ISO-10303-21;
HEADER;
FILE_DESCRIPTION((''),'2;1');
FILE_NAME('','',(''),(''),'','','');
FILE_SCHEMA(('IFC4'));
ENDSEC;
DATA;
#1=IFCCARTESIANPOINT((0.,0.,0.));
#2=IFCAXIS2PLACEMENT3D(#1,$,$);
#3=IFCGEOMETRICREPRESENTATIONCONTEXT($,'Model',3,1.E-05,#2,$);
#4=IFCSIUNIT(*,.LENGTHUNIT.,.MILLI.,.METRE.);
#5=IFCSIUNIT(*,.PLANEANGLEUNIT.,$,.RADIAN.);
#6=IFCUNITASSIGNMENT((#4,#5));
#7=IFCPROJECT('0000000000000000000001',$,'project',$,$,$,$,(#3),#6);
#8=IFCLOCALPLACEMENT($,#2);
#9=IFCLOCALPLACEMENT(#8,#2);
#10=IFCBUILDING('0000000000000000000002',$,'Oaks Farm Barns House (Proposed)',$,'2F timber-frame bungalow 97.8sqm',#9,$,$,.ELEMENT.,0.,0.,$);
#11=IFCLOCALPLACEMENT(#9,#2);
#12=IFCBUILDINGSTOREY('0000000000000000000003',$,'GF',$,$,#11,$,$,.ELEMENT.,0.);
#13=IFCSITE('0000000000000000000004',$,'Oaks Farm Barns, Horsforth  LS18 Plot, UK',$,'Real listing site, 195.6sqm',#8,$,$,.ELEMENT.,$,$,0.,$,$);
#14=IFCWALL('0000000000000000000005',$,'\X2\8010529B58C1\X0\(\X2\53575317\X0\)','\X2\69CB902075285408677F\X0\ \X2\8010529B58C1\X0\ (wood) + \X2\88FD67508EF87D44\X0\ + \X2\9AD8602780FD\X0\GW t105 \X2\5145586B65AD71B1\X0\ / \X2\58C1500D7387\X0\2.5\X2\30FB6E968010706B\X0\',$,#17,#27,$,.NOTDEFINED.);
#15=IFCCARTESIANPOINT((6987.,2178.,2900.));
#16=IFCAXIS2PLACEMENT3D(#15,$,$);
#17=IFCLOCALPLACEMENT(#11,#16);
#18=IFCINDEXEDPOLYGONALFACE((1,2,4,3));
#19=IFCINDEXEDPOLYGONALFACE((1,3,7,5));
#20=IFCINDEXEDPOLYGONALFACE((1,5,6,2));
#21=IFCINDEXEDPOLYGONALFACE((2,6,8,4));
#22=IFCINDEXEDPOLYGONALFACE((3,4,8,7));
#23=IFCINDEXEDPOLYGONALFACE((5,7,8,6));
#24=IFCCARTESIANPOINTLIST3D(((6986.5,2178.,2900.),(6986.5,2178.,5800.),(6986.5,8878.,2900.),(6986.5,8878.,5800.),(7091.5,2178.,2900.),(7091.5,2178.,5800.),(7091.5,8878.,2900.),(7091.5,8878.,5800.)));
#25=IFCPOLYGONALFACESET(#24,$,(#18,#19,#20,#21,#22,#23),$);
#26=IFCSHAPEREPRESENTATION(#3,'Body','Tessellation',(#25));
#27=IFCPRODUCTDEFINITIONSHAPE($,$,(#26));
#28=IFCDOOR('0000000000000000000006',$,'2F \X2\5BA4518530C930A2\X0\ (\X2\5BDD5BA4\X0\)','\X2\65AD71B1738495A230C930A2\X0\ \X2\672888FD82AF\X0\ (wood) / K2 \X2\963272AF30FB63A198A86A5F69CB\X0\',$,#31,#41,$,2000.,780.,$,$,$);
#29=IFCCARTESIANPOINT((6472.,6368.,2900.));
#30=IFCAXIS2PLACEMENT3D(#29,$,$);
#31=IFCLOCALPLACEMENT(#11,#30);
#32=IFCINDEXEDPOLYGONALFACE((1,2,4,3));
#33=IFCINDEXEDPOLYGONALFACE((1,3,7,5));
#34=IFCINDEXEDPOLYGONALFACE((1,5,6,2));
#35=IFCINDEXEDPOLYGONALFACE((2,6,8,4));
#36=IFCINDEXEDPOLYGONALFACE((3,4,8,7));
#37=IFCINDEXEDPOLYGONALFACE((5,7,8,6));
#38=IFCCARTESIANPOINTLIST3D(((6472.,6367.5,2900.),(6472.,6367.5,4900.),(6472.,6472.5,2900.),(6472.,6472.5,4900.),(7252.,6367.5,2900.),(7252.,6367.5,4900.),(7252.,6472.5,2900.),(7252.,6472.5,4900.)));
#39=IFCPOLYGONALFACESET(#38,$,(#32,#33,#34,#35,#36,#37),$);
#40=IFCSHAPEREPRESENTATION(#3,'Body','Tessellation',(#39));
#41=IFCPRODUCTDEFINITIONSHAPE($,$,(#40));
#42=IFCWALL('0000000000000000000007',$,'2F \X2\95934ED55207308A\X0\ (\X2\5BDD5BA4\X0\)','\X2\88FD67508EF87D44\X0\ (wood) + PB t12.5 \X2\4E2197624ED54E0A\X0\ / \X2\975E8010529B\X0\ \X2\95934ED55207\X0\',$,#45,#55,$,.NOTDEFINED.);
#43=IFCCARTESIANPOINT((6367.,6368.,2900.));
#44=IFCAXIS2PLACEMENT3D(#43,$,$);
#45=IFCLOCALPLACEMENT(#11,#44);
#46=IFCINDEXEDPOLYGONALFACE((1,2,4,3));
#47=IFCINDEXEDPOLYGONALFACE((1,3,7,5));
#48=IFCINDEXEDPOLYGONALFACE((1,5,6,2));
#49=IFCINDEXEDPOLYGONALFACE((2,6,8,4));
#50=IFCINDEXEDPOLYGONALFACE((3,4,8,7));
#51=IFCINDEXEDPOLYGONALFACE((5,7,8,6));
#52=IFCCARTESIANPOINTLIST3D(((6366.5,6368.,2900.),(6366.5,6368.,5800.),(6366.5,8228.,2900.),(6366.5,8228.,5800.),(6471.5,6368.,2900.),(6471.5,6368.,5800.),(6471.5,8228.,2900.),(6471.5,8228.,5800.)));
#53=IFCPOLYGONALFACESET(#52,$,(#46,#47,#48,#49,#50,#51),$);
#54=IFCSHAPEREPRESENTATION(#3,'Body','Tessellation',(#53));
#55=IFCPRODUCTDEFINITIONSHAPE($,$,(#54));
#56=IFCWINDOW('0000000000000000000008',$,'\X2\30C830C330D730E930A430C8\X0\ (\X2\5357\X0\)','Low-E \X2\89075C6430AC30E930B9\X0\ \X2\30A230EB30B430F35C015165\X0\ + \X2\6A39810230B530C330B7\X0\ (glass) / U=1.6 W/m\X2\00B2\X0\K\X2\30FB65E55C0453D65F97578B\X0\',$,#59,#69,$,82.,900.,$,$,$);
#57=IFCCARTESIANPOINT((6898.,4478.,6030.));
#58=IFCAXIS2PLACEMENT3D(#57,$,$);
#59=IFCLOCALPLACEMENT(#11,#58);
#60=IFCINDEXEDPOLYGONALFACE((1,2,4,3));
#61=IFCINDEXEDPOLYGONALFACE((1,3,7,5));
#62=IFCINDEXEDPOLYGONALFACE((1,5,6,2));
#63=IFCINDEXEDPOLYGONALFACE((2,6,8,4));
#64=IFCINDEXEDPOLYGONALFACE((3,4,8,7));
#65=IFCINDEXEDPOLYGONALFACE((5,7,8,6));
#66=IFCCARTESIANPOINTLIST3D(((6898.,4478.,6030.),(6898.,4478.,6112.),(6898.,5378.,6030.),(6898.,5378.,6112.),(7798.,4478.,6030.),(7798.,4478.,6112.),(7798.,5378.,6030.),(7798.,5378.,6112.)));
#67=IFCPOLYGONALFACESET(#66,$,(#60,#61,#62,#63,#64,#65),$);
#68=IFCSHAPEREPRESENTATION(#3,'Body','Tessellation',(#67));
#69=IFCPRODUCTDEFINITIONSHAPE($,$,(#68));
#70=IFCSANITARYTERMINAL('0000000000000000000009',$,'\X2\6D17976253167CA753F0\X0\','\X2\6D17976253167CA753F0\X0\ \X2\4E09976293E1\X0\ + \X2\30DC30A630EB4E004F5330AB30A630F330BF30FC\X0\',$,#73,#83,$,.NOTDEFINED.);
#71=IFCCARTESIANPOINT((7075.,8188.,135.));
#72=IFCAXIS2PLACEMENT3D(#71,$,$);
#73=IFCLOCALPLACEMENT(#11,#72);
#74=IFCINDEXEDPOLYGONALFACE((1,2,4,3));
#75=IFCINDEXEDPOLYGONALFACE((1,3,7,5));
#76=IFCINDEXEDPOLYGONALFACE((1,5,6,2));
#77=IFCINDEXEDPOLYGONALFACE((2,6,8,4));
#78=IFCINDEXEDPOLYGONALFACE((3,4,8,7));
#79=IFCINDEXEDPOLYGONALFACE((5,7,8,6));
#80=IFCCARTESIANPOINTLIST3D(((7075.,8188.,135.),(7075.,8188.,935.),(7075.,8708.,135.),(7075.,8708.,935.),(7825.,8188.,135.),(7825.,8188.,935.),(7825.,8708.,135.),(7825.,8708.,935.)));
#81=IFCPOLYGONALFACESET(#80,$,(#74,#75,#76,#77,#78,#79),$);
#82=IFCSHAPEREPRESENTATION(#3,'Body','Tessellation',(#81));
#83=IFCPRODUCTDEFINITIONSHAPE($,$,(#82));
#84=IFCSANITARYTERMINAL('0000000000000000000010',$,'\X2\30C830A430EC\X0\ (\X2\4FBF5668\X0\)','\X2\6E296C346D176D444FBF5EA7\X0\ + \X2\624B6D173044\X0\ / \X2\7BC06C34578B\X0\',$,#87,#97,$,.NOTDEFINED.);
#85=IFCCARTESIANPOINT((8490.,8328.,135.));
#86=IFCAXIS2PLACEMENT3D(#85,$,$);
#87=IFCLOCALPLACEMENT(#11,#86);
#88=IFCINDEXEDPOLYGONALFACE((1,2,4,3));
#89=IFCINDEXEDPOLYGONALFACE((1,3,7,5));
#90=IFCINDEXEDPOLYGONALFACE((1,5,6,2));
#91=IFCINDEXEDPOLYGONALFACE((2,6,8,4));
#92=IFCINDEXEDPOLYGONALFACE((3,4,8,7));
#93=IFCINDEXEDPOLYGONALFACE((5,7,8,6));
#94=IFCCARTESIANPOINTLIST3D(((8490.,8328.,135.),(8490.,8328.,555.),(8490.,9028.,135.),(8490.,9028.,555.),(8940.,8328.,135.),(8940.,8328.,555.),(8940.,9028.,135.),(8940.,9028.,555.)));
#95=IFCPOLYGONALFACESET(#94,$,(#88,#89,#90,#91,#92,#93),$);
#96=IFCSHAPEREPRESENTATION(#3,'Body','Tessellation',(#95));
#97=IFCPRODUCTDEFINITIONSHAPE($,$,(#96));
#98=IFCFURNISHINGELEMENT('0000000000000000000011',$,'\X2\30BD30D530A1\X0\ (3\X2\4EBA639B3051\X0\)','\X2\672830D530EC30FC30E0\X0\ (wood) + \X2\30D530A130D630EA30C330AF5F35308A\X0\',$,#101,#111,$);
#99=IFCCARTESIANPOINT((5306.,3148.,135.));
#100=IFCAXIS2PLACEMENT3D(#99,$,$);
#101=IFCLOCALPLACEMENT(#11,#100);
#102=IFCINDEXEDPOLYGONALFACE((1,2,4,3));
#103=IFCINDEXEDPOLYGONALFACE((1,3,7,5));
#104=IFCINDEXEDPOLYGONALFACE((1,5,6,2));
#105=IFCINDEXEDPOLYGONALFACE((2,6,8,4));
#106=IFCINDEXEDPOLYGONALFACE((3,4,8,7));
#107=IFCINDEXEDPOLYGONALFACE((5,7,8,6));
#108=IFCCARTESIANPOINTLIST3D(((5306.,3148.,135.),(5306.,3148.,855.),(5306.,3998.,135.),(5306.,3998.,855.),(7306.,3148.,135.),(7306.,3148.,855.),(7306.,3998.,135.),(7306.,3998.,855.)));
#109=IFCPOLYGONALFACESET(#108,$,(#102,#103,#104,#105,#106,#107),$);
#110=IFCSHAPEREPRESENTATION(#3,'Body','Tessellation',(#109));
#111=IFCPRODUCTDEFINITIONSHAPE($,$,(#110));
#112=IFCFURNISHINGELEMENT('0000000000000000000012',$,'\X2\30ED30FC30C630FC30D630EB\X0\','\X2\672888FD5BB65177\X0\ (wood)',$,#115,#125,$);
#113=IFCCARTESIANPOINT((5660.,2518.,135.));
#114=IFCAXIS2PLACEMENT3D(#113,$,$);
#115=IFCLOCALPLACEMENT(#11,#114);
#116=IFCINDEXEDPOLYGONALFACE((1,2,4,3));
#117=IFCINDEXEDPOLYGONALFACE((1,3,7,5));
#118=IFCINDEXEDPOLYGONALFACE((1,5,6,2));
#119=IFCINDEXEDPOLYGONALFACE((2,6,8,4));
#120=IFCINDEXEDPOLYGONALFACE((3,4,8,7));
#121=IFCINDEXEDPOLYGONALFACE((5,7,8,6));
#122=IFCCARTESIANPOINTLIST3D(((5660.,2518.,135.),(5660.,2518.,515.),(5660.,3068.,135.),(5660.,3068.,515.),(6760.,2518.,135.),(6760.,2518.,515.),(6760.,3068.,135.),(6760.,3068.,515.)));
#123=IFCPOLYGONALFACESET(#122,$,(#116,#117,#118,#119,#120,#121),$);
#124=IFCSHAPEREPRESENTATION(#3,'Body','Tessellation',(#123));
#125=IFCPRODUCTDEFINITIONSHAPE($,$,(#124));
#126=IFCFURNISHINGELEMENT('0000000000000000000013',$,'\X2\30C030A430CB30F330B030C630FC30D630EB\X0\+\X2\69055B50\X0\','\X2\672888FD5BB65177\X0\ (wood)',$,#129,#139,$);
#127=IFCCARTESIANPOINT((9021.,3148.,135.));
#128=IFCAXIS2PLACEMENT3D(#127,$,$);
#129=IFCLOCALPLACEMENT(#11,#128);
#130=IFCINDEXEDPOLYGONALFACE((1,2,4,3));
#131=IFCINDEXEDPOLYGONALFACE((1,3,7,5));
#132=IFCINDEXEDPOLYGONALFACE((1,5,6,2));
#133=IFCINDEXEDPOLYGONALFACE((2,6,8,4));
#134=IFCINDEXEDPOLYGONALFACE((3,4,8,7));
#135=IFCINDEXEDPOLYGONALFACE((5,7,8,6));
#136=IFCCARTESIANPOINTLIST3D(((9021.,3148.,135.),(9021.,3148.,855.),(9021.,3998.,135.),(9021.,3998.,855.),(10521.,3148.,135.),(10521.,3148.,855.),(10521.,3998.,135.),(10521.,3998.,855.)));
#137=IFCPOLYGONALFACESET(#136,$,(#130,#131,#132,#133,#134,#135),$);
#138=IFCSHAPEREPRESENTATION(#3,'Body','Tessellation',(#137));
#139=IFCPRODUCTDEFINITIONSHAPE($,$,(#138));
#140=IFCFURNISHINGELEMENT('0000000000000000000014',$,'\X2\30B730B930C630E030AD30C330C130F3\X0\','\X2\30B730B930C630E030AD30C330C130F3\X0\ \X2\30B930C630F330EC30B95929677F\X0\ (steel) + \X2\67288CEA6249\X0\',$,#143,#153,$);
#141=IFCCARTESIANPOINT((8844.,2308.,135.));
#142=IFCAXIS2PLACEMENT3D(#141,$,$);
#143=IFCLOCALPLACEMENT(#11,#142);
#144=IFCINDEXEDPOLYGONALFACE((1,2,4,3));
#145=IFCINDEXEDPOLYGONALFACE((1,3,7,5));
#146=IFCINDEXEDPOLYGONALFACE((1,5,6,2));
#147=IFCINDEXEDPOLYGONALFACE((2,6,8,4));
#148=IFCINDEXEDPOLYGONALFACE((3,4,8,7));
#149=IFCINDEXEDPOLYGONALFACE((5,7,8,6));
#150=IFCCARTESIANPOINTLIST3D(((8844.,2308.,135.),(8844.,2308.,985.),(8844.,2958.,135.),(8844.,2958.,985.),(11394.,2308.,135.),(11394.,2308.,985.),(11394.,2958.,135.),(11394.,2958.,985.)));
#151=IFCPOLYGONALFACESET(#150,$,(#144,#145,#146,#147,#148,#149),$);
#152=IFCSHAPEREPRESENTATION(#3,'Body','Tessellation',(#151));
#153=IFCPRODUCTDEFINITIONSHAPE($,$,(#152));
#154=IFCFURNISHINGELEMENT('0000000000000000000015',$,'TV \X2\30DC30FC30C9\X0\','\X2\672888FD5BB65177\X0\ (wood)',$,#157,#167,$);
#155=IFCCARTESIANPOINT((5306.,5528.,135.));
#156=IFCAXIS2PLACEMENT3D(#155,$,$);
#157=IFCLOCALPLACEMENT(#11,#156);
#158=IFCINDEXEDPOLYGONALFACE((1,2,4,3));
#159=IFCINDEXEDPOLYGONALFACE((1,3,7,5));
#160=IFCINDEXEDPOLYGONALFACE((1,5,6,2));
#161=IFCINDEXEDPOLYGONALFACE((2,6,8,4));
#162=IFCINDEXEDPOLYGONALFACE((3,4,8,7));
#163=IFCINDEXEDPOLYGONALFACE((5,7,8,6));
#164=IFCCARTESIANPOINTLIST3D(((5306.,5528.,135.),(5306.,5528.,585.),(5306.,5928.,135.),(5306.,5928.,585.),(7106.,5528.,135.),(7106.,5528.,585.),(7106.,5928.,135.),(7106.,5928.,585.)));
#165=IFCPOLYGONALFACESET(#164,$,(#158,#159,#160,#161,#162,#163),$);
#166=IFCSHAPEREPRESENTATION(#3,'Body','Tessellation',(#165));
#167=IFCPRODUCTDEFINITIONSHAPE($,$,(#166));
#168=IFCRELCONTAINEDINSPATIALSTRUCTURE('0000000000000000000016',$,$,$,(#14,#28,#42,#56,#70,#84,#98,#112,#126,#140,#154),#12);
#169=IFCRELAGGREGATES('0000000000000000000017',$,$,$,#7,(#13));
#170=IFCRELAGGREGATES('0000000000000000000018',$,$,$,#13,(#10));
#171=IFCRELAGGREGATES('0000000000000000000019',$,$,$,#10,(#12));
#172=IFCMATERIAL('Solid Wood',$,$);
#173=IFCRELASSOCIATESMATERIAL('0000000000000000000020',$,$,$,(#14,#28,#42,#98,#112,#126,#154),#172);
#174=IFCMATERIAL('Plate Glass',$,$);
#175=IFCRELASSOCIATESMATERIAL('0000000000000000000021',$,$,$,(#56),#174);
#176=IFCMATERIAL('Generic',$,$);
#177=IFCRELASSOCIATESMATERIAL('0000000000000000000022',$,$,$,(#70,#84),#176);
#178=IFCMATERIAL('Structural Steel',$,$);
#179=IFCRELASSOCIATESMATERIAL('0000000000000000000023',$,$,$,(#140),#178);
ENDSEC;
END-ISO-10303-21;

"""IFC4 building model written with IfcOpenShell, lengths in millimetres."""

from ifc_helpers import new_model, si_unit, frame, frame_2d, origin, place, context, project, spatial, rectangle, extrude, material, element, fill, save


model = new_model("IFC4")

# Units and contexts
model_context = context("Model", 3, precision=1e-05, world=origin())
ifc_project = project(units=[si_unit("LENGTHUNIT", "METRE", prefix="MILLI"), si_unit("PLANEANGLEUNIT", "RADIAN")], contexts=[model_context])

# Site, building, storey
site_placement = place(None, origin())
site = spatial("IfcSite", under=ifc_project, at=site_placement, Name="Oaks Farm Barns, Horsforth  LS18 Plot, UK", ObjectType="Real listing site, 195.6sqm", CompositionType="ELEMENT", RefElevation=0.0)
building_placement = place(site_placement, origin())
building = spatial("IfcBuilding", under=site, at=building_placement, Name="Oaks Farm Barns House (Proposed)", ObjectType="2F timber-frame bungalow 97.8sqm", CompositionType="ELEMENT", ElevationOfRefHeight=0.0, ElevationOfTerrain=0.0)
storey_placement = place(building_placement, origin())
storey = spatial("IfcBuildingStorey", under=building, at=storey_placement, Name="GF", CompositionType="ELEMENT", Elevation=0.0)

# Shared definitions
ifc_material_1 = material(Name="Solid Wood")

# Wall, opening, door
wall_1_placement = place(storey_placement, frame((6987.0, 2178.0, 2900.0)))
wall_1 = element("IfcWall", 1, at=wall_1_placement, inside=storey, material=ifc_material_1, Name="耐力壁(南北)", Description="構造用合板 耐力壁 (wood) + 製材軸組 + 高性能GW t105 充填断熱 / 壁倍率2.5・準耐火", PredefinedType="NOTDEFINED", context=model_context, shape_type="SweptSolid", body=[
    extrude(rectangle(XDim=105.0, YDim=6700.0, at=frame_2d((52.0, 3350.0))), frame((6987.0, 2178.0, 2900.0)), (0.0, 0.0, 1.0), 2900.0),
])
opening_1_placement = place(storey_placement, frame((6472.0, 6368.0, 2900.0)))
opening_1 = element("IfcOpeningElement", 2, at=opening_1_placement, cuts=wall_1, PredefinedType="NOTDEFINED", context=model_context, shape_type="SweptSolid", body=[
    extrude(rectangle(XDim=780.0, YDim=105.0, at=frame_2d((390.0, 52.0))), frame((6472.0, 6368.0, 2900.0)), (0.0, 0.0, 1.0), 2000.0),
])
door_1_placement = place(storey_placement, frame((6472.0, 6368.0, 2900.0)))
door_1 = element("IfcDoor", 3, at=door_1_placement, inside=storey, material=ifc_material_1, Name="2F 室内ドア (寝室)", Description="断熱玄関ドア 木製芯 (wood) / K2 防犯・採風機構", OverallHeight=2000.0, OverallWidth=780.0, context=model_context, shape_type="SweptSolid", body=[
    extrude(rectangle(XDim=780.0, YDim=105.0, at=frame_2d((390.0, 52.0))), frame((6472.0, 6368.0, 2900.0)), (0.0, 0.0, 1.0), 2000.0),
])
fill(opening_1, door_1)

# Wall
wall_2_placement = place(storey_placement, frame((6367.0, 6368.0, 2900.0)))
element("IfcWall", 4, at=wall_2_placement, inside=storey, material=ifc_material_1, Name="2F 間仕切り (寝室)", Description="製材軸組 (wood) + PB t12.5 両面仕上 / 非耐力 間仕切", PredefinedType="NOTDEFINED", context=model_context, shape_type="SweptSolid", body=[
    extrude(rectangle(XDim=105.0, YDim=1860.0, at=frame_2d((52.0, 930.0))), frame((6367.0, 6368.0, 2900.0)), (0.0, 0.0, 1.0), 2900.0),
])

# Window
ifc_material_2 = material(Name="Plate Glass")
window_placement = place(storey_placement, frame((6898.0, 4478.0, 6030.0)))
element("IfcWindow", 5, at=window_placement, inside=storey, material=ifc_material_2, Name="トップライト (南)", Description="Low-E 複層ガラス アルゴン封入 + 樹脂サッシ (glass) / U=1.6 W/m²K・日射取得型", OverallHeight=82.0, OverallWidth=900.0, context=model_context, shape_type="SweptSolid", body=[
    extrude(rectangle(XDim=900.0, YDim=900.0, at=frame_2d((450.0, 450.0))), frame((6898.0, 4478.0, 6030.0)), (0.0, 0.0, 1.0), 82.0),
])

# Sanitary terminals
ifc_material_3 = material(Name="Generic")
sanitary_terminal_1_placement = place(storey_placement, frame((7075.0, 8188.0, 135.0)))
element("IfcSanitaryTerminal", 6, at=sanitary_terminal_1_placement, inside=storey, material=ifc_material_3, Name="洗面化粧台", Description="洗面化粧台 三面鏡 + ボウル一体カウンター", PredefinedType="NOTDEFINED", context=model_context, shape_type="SweptSolid", body=[
    extrude(rectangle(XDim=750.0, YDim=520.0, at=frame_2d((375.0, 260.0))), frame((7075.0, 8188.0, 135.0)), (0.0, 0.0, 1.0), 800.0),
])
sanitary_terminal_2_placement = place(storey_placement, frame((8490.0, 8328.0, 135.0)))
element("IfcSanitaryTerminal", 7, at=sanitary_terminal_2_placement, inside=storey, material=ifc_material_3, Name="トイレ (便器)", Description="温水洗浄便座 + 手洗い / 節水型", PredefinedType="NOTDEFINED", context=model_context, shape_type="SweptSolid", body=[
    extrude(rectangle(XDim=450.0, YDim=700.0, at=frame_2d((225.0, 350.0))), frame((8490.0, 8328.0, 135.0)), (0.0, 0.0, 1.0), 420.0),
])

# Furnishing elements
furnishing_1_placement = place(storey_placement, frame((5306.0, 3148.0, 135.0)))
element("IfcFurnishingElement", 8, at=furnishing_1_placement, inside=storey, material=ifc_material_1, Name="ソファ (3人掛け)", Description="木フレーム (wood) + ファブリック張り", context=model_context, shape_type="SweptSolid", body=[
    extrude(rectangle(XDim=2000.0, YDim=850.0, at=frame_2d((1000.0, 425.0))), frame((5306.0, 3148.0, 135.0)), (0.0, 0.0, 1.0), 720.0),
])
furnishing_2_placement = place(storey_placement, frame((5660.0, 2518.0, 135.0)))
element("IfcFurnishingElement", 9, at=furnishing_2_placement, inside=storey, material=ifc_material_1, Name="ローテーブル", Description="木製家具 (wood)", context=model_context, shape_type="SweptSolid", body=[
    extrude(rectangle(XDim=1100.0, YDim=550.0, at=frame_2d((550.0, 275.0))), frame((5660.0, 2518.0, 135.0)), (0.0, 0.0, 1.0), 380.0),
])
furnishing_3_placement = place(storey_placement, frame((9021.0, 3148.0, 135.0)))
element("IfcFurnishingElement", 10, at=furnishing_3_placement, inside=storey, material=ifc_material_1, Name="ダイニングテーブル+椅子", Description="木製家具 (wood)", context=model_context, shape_type="SweptSolid", body=[
    extrude(rectangle(XDim=1500.0, YDim=850.0, at=frame_2d((750.0, 425.0))), frame((9021.0, 3148.0, 135.0)), (0.0, 0.0, 1.0), 720.0),
])
ifc_material_4 = material(Name="Structural Steel")
furnishing_4_placement = place(storey_placement, frame((8844.0, 2308.0, 135.0)))
element("IfcFurnishingElement", 11, at=furnishing_4_placement, inside=storey, material=ifc_material_4, Name="システムキッチン", Description="システムキッチン ステンレス天板 (steel) + 木質扉", context=model_context, shape_type="SweptSolid", body=[
    extrude(rectangle(XDim=2550.0, YDim=650.0, at=frame_2d((1275.0, 325.0))), frame((8844.0, 2308.0, 135.0)), (0.0, 0.0, 1.0), 850.0),
])
furnishing_5_placement = place(storey_placement, frame((5306.0, 5528.0, 135.0)))
element("IfcFurnishingElement", 12, at=furnishing_5_placement, inside=storey, material=ifc_material_1, Name="TV ボード", Description="木製家具 (wood)", context=model_context, shape_type="SweptSolid", body=[
    extrude(rectangle(XDim=1800.0, YDim=400.0, at=frame_2d((900.0, 200.0))), frame((5306.0, 5528.0, 135.0)), (0.0, 0.0, 1.0), 450.0),
])

save(model, "model.ifc")
